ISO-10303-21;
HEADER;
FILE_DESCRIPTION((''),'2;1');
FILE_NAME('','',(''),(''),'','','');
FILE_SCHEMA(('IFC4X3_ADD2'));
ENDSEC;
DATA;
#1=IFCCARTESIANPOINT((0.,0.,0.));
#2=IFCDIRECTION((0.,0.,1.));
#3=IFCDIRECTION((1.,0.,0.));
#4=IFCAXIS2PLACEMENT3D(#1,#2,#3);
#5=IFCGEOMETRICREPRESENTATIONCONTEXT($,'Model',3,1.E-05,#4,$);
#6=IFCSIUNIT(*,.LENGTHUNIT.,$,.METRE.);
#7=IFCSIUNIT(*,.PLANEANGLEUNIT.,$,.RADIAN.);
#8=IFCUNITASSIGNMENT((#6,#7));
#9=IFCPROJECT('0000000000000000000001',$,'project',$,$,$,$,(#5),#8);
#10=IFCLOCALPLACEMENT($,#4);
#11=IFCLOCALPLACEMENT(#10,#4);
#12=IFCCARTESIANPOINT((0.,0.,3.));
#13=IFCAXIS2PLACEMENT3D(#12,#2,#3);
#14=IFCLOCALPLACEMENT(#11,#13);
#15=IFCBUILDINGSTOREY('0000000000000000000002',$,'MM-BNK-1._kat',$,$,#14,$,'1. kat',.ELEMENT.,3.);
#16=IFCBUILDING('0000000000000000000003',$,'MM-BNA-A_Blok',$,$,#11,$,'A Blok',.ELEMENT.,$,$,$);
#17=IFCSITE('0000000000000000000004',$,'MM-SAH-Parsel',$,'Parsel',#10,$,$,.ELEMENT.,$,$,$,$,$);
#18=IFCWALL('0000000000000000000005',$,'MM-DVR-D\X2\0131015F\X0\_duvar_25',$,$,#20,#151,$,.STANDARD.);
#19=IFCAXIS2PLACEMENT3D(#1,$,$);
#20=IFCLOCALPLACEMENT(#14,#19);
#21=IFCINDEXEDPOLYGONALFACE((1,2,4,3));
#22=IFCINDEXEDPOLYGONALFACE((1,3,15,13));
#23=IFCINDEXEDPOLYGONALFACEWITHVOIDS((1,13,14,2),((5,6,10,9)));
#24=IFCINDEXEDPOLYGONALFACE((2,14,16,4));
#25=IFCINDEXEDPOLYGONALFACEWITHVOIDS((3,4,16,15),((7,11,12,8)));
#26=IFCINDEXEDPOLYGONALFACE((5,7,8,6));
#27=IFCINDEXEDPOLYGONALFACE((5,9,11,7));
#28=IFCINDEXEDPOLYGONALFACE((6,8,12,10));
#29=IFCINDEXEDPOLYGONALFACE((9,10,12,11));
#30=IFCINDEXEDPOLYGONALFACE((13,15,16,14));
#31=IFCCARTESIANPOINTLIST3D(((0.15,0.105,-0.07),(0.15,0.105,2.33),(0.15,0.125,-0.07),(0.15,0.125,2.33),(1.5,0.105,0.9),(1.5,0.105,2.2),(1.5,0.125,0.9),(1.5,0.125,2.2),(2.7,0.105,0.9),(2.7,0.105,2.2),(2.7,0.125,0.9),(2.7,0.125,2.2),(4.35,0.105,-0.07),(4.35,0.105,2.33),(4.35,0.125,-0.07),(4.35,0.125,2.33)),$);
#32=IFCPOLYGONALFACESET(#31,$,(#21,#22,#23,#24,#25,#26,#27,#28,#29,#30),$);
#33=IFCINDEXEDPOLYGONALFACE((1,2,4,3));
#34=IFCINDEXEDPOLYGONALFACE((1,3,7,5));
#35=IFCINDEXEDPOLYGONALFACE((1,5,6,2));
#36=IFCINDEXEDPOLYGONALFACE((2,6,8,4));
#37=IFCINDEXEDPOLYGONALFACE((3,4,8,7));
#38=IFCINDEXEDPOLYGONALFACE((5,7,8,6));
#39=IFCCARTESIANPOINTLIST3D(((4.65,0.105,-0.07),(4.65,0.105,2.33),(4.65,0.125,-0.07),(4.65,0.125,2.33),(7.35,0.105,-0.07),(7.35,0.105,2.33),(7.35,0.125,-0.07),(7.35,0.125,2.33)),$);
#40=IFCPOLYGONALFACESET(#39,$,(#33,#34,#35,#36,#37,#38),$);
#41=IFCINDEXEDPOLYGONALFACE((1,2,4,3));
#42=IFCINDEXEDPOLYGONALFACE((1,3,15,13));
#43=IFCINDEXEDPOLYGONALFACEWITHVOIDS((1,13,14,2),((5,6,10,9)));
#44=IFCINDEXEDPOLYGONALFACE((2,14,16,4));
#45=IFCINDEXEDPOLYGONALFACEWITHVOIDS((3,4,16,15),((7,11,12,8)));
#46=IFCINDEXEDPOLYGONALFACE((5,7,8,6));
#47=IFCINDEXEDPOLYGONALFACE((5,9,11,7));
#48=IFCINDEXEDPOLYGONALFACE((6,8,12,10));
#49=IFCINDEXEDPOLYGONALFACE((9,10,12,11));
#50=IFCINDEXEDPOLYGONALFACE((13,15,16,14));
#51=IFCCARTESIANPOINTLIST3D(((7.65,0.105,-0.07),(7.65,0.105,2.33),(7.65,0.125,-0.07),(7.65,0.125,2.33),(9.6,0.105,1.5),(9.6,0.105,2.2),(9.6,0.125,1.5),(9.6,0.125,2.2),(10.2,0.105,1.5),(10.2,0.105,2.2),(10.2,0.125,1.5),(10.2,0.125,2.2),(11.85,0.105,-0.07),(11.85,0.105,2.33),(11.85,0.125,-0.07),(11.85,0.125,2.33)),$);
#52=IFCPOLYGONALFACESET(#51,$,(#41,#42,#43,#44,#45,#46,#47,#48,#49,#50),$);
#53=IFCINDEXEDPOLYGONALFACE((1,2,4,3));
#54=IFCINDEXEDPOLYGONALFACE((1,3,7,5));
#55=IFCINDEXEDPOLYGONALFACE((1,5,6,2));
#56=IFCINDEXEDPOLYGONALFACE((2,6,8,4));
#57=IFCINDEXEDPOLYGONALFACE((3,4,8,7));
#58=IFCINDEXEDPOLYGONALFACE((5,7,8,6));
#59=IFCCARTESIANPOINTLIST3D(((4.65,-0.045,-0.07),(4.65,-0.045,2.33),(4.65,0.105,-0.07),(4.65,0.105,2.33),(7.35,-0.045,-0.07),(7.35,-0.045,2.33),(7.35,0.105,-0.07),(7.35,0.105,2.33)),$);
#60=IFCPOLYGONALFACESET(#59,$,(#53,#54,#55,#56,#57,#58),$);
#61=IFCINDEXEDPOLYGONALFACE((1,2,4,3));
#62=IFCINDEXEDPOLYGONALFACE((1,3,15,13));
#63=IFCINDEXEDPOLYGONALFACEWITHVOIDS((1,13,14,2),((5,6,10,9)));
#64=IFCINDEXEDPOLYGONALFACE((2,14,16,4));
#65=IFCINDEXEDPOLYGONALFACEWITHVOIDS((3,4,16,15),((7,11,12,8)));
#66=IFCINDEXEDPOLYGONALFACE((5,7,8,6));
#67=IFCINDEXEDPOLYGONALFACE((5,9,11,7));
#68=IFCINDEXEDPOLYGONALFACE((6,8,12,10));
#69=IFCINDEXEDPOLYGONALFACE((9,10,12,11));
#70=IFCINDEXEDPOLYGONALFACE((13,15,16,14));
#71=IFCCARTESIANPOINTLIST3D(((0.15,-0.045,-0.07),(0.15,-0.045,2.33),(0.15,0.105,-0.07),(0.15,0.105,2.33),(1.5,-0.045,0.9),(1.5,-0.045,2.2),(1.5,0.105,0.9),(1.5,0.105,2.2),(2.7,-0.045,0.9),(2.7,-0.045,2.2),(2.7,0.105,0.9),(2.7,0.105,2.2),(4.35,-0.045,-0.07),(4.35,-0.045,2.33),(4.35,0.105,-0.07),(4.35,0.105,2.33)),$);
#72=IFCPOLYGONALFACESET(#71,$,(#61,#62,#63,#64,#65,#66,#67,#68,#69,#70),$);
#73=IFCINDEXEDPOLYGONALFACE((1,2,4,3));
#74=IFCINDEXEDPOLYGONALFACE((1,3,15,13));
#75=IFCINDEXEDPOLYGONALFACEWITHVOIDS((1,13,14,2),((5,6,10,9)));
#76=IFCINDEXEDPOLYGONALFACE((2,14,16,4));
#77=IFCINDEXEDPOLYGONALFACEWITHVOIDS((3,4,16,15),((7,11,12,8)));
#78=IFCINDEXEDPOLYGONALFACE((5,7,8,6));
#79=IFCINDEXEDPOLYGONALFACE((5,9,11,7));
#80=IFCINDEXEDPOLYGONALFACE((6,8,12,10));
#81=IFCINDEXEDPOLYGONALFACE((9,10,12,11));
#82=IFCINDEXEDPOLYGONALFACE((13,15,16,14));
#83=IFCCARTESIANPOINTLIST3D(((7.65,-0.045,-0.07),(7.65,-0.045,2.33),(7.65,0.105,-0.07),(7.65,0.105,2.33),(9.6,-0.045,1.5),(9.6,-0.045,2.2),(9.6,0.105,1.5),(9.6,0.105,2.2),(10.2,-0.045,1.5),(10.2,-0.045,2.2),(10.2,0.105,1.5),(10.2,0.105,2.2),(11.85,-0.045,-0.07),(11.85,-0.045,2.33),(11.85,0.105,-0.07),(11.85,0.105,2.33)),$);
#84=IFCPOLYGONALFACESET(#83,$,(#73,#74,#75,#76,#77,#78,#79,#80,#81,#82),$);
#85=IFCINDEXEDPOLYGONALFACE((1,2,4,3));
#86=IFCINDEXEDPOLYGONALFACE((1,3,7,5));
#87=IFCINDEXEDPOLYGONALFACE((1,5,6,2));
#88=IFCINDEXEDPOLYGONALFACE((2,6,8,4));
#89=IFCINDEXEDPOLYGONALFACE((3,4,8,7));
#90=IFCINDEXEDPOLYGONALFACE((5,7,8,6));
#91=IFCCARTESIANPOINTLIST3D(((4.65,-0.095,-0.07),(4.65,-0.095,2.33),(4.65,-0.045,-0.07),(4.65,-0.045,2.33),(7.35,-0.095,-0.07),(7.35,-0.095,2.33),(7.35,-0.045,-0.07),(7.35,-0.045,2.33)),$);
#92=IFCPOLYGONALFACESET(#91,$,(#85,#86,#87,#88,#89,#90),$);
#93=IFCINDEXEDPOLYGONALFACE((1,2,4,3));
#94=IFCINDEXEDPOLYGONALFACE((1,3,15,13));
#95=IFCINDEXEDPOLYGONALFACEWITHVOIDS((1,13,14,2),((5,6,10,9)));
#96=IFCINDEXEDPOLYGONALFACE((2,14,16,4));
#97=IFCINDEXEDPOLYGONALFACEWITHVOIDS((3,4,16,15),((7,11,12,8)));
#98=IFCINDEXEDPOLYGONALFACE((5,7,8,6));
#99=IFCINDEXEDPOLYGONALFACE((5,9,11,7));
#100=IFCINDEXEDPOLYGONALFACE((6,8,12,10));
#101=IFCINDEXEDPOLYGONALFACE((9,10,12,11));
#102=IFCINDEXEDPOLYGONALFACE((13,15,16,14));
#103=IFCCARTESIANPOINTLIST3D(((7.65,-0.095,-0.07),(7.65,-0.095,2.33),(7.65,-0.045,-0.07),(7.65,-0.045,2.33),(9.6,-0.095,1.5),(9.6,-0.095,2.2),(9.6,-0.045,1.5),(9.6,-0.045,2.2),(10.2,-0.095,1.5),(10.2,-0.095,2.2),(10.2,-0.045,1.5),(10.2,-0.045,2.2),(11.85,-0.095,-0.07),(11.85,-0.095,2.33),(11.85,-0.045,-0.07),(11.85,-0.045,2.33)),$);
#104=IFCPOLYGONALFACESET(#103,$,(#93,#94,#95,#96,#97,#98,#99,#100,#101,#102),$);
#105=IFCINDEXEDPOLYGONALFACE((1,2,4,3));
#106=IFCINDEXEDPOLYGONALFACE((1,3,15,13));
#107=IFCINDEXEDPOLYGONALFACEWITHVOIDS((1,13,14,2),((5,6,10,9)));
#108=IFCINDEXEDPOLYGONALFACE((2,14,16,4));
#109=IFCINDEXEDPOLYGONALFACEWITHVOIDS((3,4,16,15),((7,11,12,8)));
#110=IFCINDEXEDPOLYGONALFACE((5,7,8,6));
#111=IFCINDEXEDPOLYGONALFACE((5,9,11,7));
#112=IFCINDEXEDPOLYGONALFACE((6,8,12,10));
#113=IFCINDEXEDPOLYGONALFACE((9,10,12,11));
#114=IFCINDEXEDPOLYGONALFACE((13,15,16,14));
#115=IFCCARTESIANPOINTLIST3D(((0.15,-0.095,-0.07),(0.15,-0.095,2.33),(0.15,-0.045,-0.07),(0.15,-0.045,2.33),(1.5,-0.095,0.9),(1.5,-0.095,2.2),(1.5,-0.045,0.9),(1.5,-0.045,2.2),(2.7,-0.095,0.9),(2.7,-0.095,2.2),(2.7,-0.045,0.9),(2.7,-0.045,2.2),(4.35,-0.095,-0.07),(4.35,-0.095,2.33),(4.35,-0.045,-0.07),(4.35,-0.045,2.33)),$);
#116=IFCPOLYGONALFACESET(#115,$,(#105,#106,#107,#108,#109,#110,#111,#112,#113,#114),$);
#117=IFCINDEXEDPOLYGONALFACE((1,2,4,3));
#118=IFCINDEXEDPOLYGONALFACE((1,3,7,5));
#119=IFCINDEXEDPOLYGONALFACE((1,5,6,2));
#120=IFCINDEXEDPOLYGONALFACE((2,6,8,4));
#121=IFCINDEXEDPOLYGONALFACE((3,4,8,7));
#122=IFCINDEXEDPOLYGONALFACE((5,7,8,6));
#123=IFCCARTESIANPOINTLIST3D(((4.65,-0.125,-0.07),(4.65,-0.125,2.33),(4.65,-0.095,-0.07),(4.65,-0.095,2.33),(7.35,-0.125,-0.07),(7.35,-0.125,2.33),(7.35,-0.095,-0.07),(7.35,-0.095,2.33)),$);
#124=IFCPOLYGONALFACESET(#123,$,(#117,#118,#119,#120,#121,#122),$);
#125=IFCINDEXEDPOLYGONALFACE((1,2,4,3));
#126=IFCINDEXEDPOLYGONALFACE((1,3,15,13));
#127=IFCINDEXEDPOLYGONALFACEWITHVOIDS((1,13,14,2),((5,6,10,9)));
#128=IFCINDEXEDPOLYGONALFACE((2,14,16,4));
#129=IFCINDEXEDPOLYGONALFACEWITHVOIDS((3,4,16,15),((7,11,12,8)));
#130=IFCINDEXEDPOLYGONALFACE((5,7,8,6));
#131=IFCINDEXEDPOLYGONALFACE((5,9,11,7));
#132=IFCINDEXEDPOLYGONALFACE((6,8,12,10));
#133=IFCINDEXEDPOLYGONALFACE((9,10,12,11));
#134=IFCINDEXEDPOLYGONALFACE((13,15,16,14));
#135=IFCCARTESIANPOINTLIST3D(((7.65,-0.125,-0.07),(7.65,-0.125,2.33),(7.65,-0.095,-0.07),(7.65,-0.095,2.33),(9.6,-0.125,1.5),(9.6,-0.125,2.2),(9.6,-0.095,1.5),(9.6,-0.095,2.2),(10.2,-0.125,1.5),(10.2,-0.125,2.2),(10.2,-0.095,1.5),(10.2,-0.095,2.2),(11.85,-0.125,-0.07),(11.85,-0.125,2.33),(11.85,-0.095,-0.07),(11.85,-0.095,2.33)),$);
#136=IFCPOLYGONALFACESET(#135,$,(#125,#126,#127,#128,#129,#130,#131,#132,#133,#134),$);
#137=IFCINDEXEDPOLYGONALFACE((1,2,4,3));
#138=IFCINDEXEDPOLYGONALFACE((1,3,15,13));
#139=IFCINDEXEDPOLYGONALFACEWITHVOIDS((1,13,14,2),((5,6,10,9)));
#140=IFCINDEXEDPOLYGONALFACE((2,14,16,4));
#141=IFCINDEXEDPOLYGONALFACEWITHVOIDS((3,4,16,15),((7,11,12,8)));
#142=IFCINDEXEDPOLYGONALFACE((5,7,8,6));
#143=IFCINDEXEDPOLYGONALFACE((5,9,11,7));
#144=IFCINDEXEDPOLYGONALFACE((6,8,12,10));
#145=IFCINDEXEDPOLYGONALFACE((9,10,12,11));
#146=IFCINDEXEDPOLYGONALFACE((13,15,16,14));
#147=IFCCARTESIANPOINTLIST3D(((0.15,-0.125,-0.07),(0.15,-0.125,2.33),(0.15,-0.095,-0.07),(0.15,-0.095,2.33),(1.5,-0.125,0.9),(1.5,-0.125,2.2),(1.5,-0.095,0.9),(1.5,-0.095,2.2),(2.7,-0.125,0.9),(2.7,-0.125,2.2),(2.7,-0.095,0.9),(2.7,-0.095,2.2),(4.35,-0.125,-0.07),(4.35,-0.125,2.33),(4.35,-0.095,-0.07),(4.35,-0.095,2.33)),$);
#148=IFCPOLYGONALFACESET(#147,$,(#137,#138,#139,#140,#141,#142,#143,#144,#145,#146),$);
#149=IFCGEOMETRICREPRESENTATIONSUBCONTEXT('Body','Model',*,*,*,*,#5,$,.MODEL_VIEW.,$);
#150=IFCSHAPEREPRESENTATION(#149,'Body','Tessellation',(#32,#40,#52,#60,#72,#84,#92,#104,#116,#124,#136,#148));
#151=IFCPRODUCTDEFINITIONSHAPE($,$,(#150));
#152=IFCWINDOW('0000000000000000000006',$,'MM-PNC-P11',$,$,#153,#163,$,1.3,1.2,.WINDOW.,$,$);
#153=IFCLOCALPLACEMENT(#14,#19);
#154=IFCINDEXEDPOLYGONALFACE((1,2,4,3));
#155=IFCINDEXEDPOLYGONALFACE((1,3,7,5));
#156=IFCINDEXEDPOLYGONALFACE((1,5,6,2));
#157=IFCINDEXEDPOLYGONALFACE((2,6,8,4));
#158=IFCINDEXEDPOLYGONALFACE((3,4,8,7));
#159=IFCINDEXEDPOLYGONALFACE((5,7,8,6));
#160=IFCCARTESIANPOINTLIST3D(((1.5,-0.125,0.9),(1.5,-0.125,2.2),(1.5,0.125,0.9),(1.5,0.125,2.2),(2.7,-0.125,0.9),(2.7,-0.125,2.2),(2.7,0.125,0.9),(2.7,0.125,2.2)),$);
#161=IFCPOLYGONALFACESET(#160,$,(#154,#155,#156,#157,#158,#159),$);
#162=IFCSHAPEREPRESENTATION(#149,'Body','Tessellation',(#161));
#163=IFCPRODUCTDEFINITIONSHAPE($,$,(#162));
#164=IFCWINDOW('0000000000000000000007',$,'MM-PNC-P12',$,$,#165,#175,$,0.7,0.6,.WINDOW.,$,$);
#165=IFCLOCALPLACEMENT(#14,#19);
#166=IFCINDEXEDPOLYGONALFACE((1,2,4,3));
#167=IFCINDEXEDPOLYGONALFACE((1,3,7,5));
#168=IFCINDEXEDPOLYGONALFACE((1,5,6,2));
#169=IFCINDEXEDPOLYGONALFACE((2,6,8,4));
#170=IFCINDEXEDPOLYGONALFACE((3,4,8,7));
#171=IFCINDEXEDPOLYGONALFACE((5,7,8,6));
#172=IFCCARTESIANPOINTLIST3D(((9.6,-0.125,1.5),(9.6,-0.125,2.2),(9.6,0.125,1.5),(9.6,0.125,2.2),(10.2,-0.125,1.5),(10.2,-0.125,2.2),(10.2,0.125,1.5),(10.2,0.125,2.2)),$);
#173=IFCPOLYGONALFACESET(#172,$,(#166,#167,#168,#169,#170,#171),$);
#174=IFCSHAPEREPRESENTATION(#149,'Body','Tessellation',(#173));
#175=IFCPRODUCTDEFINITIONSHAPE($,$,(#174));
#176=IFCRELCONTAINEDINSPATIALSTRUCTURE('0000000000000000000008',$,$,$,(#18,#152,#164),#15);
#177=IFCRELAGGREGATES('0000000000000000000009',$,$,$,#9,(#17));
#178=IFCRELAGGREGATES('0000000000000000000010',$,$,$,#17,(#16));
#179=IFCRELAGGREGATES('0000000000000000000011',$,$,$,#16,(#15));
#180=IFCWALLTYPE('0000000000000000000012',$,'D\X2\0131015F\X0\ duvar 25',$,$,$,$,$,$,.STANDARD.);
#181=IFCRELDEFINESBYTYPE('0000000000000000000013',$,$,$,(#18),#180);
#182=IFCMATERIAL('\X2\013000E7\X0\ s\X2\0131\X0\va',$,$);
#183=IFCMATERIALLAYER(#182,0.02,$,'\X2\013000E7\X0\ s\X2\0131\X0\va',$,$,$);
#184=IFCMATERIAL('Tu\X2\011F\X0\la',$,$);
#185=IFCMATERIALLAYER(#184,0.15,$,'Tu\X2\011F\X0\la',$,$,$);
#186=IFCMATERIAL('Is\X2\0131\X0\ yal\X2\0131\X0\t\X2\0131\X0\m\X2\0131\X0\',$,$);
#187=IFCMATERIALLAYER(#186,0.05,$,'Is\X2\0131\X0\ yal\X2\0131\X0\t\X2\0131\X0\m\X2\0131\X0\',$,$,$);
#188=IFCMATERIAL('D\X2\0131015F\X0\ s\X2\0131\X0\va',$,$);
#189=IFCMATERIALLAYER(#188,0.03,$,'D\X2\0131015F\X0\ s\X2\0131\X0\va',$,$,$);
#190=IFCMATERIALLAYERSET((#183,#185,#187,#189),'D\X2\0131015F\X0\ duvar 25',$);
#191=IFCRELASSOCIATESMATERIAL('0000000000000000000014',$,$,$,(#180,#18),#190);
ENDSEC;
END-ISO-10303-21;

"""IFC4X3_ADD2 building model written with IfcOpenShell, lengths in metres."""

from ifc_helpers import new_model, si_unit, frame, origin_with_axes, place, context, subcontext, project, spatial, polyline, outline, extrude, material, layer, layer_set, type_object, element, fill, save


model = new_model("IFC4X3_ADD2")

# Units and contexts
model_context = context("Model", 3, precision=1e-05, world=origin_with_axes())
body_context = subcontext(model_context, "Body", "Model", "MODEL_VIEW")
ifc_project = project(units=[si_unit("LENGTHUNIT", "METRE"), si_unit("PLANEANGLEUNIT", "RADIAN")], contexts=[model_context])

# Site, building, storey
site_placement = place(None, origin_with_axes())
site = spatial("IfcSite", under=ifc_project, at=site_placement, Name="MM-SAH-Parsel", ObjectType="Parsel", CompositionType="ELEMENT")
building_placement = place(site_placement, origin_with_axes())
building = spatial("IfcBuilding", under=site, at=building_placement, Name="MM-BNA-A_Blok", LongName="A Blok", CompositionType="ELEMENT")
storey_placement = place(building_placement, frame((0.0, 0.0, 3.0), z_axis=(0.0, 0.0, 1.0), x_axis=(1.0, 0.0, 0.0)))
storey = spatial("IfcBuildingStorey", under=building, at=storey_placement, Name="MM-BNK-1._kat", LongName="1. kat", CompositionType="ELEMENT", Elevation=3.0)

# Wall, openings, windows
ifc_material_1 = material(Name="İç sıva")
ifc_layer_1 = layer(ifc_material_1, 0.02, Name="İç sıva")
ifc_material_2 = material(Name="Tuğla")
ifc_layer_2 = layer(ifc_material_2, 0.15, Name="Tuğla")
ifc_material_3 = material(Name="Isı yalıtımı")
ifc_layer_3 = layer(ifc_material_3, 0.05, Name="Isı yalıtımı")
ifc_material_4 = material(Name="Dış sıva")
ifc_layer_4 = layer(ifc_material_4, 0.03, Name="Dış sıva")
ifc_layer_set_1 = layer_set([ifc_layer_1, ifc_layer_2, ifc_layer_3, ifc_layer_4], Name="Dış duvar 25")
wall_type_1 = type_object("IfcWallType", Name="Dış duvar 25", PredefinedType="STANDARD", material=ifc_layer_set_1)
wall_1_placement = place(storey_placement, origin_with_axes())
wall_1 = element("IfcWall", 1, at=wall_1_placement, inside=storey, type_object=wall_type_1, material=ifc_layer_set_1, Name="MM-DVR-Dış_duvar_25", PredefinedType="STANDARD", context=body_context, shape_type="SweptSolid", body=[
    extrude(outline(polyline([(0.15, 0.105), (4.35, 0.105), (4.35, 0.125), (0.15, 0.125), (0.15, 0.105)])), frame((0.0, 0.0, -0.07)), (0.0, 0.0, 1.0), 2.4),
    extrude(outline(polyline([(4.65, 0.105), (7.35, 0.105), (7.35, 0.125), (4.65, 0.125), (4.65, 0.105)])), frame((0.0, 0.0, -0.07)), (0.0, 0.0, 1.0), 2.4),
    extrude(outline(polyline([(7.65, 0.105), (11.85, 0.105), (11.85, 0.125), (7.65, 0.125), (7.65, 0.105)])), frame((0.0, 0.0, -0.07)), (0.0, 0.0, 1.0), 2.4),
    extrude(outline(polyline([(4.65, -0.045), (7.35, -0.045), (7.35, 0.105), (4.65, 0.105), (4.65, -0.045)])), frame((0.0, 0.0, -0.07)), (0.0, 0.0, 1.0), 2.4),
    extrude(outline(polyline([(0.15, -0.045), (4.35, -0.045), (4.35, 0.105), (0.15, 0.105), (0.15, -0.045)])), frame((0.0, 0.0, -0.07)), (0.0, 0.0, 1.0), 2.4),
    extrude(outline(polyline([(7.65, -0.045), (11.85, -0.045), (11.85, 0.105), (7.65, 0.105), (7.65, -0.045)])), frame((0.0, 0.0, -0.07)), (0.0, 0.0, 1.0), 2.4),
    extrude(outline(polyline([(4.65, -0.095), (7.35, -0.095), (7.35, -0.045), (4.65, -0.045), (4.65, -0.095)])), frame((0.0, 0.0, -0.07)), (0.0, 0.0, 1.0), 2.4),
    extrude(outline(polyline([(7.65, -0.095), (11.85, -0.095), (11.85, -0.045), (7.65, -0.045), (7.65, -0.095)])), frame((0.0, 0.0, -0.07)), (0.0, 0.0, 1.0), 2.4),
    extrude(outline(polyline([(0.15, -0.095), (4.35, -0.095), (4.35, -0.045), (0.15, -0.045), (0.15, -0.095)])), frame((0.0, 0.0, -0.07)), (0.0, 0.0, 1.0), 2.4),
    extrude(outline(polyline([(4.65, -0.125), (7.35, -0.125), (7.35, -0.095), (4.65, -0.095), (4.65, -0.125)])), frame((0.0, 0.0, -0.07)), (0.0, 0.0, 1.0), 2.4),
    extrude(outline(polyline([(7.65, -0.125), (11.85, -0.125), (11.85, -0.095), (7.65, -0.095), (7.65, -0.125)])), frame((0.0, 0.0, -0.07)), (0.0, 0.0, 1.0), 2.4),
    extrude(outline(polyline([(0.15, -0.125), (4.35, -0.125), (4.35, -0.095), (0.15, -0.095), (0.15, -0.125)])), frame((0.0, 0.0, -0.07)), (0.0, 0.0, 1.0), 2.4),
])
opening_1_placement = place(storey_placement, origin_with_axes())
opening_1 = element("IfcOpeningElement", 2, at=opening_1_placement, cuts=wall_1, PredefinedType="OPENING", context=body_context, shape_type="SweptSolid", body=[
    extrude(outline(polyline([(1.5, 0.125), (2.7, 0.125), (2.7, -0.125), (1.5, -0.125), (1.5, 0.125)])), frame((0.0, 0.0, 0.9)), (0.0, 0.0, 1.0), 1.3),
])
opening_2_placement = place(storey_placement, origin_with_axes())
opening_2 = element("IfcOpeningElement", 3, at=opening_2_placement, cuts=wall_1, PredefinedType="OPENING", context=body_context, shape_type="SweptSolid", body=[
    extrude(outline(polyline([(9.6, 0.125), (10.2, 0.125), (10.2, -0.125), (9.6, -0.125), (9.6, 0.125)])), frame((0.0, 0.0, 1.5)), (0.0, 0.0, 1.0), 0.7),
])
window_1_placement = place(storey_placement, origin_with_axes())
window_1 = element("IfcWindow", 4, at=window_1_placement, inside=storey, Name="MM-PNC-P11", OverallHeight=1.3, OverallWidth=1.2, PredefinedType="WINDOW", context=body_context, shape_type="SweptSolid", body=[
    extrude(outline(polyline([(1.5, 0.125), (2.7, 0.125), (2.7, -0.125), (1.5, -0.125), (1.5, 0.125)])), frame((0.0, 0.0, 0.9)), (0.0, 0.0, 1.0), 1.3),
])
fill(opening_1, window_1)
window_2_placement = place(storey_placement, origin_with_axes())
window_2 = element("IfcWindow", 5, at=window_2_placement, inside=storey, Name="MM-PNC-P12", OverallHeight=0.7, OverallWidth=0.6, PredefinedType="WINDOW", context=body_context, shape_type="SweptSolid", body=[
    extrude(outline(polyline([(9.6, 0.125), (10.2, 0.125), (10.2, -0.125), (9.6, -0.125), (9.6, 0.125)])), frame((0.0, 0.0, 1.5)), (0.0, 0.0, 1.0), 0.7),
])
fill(opening_2, window_2)

save(model, "model.ifc")
